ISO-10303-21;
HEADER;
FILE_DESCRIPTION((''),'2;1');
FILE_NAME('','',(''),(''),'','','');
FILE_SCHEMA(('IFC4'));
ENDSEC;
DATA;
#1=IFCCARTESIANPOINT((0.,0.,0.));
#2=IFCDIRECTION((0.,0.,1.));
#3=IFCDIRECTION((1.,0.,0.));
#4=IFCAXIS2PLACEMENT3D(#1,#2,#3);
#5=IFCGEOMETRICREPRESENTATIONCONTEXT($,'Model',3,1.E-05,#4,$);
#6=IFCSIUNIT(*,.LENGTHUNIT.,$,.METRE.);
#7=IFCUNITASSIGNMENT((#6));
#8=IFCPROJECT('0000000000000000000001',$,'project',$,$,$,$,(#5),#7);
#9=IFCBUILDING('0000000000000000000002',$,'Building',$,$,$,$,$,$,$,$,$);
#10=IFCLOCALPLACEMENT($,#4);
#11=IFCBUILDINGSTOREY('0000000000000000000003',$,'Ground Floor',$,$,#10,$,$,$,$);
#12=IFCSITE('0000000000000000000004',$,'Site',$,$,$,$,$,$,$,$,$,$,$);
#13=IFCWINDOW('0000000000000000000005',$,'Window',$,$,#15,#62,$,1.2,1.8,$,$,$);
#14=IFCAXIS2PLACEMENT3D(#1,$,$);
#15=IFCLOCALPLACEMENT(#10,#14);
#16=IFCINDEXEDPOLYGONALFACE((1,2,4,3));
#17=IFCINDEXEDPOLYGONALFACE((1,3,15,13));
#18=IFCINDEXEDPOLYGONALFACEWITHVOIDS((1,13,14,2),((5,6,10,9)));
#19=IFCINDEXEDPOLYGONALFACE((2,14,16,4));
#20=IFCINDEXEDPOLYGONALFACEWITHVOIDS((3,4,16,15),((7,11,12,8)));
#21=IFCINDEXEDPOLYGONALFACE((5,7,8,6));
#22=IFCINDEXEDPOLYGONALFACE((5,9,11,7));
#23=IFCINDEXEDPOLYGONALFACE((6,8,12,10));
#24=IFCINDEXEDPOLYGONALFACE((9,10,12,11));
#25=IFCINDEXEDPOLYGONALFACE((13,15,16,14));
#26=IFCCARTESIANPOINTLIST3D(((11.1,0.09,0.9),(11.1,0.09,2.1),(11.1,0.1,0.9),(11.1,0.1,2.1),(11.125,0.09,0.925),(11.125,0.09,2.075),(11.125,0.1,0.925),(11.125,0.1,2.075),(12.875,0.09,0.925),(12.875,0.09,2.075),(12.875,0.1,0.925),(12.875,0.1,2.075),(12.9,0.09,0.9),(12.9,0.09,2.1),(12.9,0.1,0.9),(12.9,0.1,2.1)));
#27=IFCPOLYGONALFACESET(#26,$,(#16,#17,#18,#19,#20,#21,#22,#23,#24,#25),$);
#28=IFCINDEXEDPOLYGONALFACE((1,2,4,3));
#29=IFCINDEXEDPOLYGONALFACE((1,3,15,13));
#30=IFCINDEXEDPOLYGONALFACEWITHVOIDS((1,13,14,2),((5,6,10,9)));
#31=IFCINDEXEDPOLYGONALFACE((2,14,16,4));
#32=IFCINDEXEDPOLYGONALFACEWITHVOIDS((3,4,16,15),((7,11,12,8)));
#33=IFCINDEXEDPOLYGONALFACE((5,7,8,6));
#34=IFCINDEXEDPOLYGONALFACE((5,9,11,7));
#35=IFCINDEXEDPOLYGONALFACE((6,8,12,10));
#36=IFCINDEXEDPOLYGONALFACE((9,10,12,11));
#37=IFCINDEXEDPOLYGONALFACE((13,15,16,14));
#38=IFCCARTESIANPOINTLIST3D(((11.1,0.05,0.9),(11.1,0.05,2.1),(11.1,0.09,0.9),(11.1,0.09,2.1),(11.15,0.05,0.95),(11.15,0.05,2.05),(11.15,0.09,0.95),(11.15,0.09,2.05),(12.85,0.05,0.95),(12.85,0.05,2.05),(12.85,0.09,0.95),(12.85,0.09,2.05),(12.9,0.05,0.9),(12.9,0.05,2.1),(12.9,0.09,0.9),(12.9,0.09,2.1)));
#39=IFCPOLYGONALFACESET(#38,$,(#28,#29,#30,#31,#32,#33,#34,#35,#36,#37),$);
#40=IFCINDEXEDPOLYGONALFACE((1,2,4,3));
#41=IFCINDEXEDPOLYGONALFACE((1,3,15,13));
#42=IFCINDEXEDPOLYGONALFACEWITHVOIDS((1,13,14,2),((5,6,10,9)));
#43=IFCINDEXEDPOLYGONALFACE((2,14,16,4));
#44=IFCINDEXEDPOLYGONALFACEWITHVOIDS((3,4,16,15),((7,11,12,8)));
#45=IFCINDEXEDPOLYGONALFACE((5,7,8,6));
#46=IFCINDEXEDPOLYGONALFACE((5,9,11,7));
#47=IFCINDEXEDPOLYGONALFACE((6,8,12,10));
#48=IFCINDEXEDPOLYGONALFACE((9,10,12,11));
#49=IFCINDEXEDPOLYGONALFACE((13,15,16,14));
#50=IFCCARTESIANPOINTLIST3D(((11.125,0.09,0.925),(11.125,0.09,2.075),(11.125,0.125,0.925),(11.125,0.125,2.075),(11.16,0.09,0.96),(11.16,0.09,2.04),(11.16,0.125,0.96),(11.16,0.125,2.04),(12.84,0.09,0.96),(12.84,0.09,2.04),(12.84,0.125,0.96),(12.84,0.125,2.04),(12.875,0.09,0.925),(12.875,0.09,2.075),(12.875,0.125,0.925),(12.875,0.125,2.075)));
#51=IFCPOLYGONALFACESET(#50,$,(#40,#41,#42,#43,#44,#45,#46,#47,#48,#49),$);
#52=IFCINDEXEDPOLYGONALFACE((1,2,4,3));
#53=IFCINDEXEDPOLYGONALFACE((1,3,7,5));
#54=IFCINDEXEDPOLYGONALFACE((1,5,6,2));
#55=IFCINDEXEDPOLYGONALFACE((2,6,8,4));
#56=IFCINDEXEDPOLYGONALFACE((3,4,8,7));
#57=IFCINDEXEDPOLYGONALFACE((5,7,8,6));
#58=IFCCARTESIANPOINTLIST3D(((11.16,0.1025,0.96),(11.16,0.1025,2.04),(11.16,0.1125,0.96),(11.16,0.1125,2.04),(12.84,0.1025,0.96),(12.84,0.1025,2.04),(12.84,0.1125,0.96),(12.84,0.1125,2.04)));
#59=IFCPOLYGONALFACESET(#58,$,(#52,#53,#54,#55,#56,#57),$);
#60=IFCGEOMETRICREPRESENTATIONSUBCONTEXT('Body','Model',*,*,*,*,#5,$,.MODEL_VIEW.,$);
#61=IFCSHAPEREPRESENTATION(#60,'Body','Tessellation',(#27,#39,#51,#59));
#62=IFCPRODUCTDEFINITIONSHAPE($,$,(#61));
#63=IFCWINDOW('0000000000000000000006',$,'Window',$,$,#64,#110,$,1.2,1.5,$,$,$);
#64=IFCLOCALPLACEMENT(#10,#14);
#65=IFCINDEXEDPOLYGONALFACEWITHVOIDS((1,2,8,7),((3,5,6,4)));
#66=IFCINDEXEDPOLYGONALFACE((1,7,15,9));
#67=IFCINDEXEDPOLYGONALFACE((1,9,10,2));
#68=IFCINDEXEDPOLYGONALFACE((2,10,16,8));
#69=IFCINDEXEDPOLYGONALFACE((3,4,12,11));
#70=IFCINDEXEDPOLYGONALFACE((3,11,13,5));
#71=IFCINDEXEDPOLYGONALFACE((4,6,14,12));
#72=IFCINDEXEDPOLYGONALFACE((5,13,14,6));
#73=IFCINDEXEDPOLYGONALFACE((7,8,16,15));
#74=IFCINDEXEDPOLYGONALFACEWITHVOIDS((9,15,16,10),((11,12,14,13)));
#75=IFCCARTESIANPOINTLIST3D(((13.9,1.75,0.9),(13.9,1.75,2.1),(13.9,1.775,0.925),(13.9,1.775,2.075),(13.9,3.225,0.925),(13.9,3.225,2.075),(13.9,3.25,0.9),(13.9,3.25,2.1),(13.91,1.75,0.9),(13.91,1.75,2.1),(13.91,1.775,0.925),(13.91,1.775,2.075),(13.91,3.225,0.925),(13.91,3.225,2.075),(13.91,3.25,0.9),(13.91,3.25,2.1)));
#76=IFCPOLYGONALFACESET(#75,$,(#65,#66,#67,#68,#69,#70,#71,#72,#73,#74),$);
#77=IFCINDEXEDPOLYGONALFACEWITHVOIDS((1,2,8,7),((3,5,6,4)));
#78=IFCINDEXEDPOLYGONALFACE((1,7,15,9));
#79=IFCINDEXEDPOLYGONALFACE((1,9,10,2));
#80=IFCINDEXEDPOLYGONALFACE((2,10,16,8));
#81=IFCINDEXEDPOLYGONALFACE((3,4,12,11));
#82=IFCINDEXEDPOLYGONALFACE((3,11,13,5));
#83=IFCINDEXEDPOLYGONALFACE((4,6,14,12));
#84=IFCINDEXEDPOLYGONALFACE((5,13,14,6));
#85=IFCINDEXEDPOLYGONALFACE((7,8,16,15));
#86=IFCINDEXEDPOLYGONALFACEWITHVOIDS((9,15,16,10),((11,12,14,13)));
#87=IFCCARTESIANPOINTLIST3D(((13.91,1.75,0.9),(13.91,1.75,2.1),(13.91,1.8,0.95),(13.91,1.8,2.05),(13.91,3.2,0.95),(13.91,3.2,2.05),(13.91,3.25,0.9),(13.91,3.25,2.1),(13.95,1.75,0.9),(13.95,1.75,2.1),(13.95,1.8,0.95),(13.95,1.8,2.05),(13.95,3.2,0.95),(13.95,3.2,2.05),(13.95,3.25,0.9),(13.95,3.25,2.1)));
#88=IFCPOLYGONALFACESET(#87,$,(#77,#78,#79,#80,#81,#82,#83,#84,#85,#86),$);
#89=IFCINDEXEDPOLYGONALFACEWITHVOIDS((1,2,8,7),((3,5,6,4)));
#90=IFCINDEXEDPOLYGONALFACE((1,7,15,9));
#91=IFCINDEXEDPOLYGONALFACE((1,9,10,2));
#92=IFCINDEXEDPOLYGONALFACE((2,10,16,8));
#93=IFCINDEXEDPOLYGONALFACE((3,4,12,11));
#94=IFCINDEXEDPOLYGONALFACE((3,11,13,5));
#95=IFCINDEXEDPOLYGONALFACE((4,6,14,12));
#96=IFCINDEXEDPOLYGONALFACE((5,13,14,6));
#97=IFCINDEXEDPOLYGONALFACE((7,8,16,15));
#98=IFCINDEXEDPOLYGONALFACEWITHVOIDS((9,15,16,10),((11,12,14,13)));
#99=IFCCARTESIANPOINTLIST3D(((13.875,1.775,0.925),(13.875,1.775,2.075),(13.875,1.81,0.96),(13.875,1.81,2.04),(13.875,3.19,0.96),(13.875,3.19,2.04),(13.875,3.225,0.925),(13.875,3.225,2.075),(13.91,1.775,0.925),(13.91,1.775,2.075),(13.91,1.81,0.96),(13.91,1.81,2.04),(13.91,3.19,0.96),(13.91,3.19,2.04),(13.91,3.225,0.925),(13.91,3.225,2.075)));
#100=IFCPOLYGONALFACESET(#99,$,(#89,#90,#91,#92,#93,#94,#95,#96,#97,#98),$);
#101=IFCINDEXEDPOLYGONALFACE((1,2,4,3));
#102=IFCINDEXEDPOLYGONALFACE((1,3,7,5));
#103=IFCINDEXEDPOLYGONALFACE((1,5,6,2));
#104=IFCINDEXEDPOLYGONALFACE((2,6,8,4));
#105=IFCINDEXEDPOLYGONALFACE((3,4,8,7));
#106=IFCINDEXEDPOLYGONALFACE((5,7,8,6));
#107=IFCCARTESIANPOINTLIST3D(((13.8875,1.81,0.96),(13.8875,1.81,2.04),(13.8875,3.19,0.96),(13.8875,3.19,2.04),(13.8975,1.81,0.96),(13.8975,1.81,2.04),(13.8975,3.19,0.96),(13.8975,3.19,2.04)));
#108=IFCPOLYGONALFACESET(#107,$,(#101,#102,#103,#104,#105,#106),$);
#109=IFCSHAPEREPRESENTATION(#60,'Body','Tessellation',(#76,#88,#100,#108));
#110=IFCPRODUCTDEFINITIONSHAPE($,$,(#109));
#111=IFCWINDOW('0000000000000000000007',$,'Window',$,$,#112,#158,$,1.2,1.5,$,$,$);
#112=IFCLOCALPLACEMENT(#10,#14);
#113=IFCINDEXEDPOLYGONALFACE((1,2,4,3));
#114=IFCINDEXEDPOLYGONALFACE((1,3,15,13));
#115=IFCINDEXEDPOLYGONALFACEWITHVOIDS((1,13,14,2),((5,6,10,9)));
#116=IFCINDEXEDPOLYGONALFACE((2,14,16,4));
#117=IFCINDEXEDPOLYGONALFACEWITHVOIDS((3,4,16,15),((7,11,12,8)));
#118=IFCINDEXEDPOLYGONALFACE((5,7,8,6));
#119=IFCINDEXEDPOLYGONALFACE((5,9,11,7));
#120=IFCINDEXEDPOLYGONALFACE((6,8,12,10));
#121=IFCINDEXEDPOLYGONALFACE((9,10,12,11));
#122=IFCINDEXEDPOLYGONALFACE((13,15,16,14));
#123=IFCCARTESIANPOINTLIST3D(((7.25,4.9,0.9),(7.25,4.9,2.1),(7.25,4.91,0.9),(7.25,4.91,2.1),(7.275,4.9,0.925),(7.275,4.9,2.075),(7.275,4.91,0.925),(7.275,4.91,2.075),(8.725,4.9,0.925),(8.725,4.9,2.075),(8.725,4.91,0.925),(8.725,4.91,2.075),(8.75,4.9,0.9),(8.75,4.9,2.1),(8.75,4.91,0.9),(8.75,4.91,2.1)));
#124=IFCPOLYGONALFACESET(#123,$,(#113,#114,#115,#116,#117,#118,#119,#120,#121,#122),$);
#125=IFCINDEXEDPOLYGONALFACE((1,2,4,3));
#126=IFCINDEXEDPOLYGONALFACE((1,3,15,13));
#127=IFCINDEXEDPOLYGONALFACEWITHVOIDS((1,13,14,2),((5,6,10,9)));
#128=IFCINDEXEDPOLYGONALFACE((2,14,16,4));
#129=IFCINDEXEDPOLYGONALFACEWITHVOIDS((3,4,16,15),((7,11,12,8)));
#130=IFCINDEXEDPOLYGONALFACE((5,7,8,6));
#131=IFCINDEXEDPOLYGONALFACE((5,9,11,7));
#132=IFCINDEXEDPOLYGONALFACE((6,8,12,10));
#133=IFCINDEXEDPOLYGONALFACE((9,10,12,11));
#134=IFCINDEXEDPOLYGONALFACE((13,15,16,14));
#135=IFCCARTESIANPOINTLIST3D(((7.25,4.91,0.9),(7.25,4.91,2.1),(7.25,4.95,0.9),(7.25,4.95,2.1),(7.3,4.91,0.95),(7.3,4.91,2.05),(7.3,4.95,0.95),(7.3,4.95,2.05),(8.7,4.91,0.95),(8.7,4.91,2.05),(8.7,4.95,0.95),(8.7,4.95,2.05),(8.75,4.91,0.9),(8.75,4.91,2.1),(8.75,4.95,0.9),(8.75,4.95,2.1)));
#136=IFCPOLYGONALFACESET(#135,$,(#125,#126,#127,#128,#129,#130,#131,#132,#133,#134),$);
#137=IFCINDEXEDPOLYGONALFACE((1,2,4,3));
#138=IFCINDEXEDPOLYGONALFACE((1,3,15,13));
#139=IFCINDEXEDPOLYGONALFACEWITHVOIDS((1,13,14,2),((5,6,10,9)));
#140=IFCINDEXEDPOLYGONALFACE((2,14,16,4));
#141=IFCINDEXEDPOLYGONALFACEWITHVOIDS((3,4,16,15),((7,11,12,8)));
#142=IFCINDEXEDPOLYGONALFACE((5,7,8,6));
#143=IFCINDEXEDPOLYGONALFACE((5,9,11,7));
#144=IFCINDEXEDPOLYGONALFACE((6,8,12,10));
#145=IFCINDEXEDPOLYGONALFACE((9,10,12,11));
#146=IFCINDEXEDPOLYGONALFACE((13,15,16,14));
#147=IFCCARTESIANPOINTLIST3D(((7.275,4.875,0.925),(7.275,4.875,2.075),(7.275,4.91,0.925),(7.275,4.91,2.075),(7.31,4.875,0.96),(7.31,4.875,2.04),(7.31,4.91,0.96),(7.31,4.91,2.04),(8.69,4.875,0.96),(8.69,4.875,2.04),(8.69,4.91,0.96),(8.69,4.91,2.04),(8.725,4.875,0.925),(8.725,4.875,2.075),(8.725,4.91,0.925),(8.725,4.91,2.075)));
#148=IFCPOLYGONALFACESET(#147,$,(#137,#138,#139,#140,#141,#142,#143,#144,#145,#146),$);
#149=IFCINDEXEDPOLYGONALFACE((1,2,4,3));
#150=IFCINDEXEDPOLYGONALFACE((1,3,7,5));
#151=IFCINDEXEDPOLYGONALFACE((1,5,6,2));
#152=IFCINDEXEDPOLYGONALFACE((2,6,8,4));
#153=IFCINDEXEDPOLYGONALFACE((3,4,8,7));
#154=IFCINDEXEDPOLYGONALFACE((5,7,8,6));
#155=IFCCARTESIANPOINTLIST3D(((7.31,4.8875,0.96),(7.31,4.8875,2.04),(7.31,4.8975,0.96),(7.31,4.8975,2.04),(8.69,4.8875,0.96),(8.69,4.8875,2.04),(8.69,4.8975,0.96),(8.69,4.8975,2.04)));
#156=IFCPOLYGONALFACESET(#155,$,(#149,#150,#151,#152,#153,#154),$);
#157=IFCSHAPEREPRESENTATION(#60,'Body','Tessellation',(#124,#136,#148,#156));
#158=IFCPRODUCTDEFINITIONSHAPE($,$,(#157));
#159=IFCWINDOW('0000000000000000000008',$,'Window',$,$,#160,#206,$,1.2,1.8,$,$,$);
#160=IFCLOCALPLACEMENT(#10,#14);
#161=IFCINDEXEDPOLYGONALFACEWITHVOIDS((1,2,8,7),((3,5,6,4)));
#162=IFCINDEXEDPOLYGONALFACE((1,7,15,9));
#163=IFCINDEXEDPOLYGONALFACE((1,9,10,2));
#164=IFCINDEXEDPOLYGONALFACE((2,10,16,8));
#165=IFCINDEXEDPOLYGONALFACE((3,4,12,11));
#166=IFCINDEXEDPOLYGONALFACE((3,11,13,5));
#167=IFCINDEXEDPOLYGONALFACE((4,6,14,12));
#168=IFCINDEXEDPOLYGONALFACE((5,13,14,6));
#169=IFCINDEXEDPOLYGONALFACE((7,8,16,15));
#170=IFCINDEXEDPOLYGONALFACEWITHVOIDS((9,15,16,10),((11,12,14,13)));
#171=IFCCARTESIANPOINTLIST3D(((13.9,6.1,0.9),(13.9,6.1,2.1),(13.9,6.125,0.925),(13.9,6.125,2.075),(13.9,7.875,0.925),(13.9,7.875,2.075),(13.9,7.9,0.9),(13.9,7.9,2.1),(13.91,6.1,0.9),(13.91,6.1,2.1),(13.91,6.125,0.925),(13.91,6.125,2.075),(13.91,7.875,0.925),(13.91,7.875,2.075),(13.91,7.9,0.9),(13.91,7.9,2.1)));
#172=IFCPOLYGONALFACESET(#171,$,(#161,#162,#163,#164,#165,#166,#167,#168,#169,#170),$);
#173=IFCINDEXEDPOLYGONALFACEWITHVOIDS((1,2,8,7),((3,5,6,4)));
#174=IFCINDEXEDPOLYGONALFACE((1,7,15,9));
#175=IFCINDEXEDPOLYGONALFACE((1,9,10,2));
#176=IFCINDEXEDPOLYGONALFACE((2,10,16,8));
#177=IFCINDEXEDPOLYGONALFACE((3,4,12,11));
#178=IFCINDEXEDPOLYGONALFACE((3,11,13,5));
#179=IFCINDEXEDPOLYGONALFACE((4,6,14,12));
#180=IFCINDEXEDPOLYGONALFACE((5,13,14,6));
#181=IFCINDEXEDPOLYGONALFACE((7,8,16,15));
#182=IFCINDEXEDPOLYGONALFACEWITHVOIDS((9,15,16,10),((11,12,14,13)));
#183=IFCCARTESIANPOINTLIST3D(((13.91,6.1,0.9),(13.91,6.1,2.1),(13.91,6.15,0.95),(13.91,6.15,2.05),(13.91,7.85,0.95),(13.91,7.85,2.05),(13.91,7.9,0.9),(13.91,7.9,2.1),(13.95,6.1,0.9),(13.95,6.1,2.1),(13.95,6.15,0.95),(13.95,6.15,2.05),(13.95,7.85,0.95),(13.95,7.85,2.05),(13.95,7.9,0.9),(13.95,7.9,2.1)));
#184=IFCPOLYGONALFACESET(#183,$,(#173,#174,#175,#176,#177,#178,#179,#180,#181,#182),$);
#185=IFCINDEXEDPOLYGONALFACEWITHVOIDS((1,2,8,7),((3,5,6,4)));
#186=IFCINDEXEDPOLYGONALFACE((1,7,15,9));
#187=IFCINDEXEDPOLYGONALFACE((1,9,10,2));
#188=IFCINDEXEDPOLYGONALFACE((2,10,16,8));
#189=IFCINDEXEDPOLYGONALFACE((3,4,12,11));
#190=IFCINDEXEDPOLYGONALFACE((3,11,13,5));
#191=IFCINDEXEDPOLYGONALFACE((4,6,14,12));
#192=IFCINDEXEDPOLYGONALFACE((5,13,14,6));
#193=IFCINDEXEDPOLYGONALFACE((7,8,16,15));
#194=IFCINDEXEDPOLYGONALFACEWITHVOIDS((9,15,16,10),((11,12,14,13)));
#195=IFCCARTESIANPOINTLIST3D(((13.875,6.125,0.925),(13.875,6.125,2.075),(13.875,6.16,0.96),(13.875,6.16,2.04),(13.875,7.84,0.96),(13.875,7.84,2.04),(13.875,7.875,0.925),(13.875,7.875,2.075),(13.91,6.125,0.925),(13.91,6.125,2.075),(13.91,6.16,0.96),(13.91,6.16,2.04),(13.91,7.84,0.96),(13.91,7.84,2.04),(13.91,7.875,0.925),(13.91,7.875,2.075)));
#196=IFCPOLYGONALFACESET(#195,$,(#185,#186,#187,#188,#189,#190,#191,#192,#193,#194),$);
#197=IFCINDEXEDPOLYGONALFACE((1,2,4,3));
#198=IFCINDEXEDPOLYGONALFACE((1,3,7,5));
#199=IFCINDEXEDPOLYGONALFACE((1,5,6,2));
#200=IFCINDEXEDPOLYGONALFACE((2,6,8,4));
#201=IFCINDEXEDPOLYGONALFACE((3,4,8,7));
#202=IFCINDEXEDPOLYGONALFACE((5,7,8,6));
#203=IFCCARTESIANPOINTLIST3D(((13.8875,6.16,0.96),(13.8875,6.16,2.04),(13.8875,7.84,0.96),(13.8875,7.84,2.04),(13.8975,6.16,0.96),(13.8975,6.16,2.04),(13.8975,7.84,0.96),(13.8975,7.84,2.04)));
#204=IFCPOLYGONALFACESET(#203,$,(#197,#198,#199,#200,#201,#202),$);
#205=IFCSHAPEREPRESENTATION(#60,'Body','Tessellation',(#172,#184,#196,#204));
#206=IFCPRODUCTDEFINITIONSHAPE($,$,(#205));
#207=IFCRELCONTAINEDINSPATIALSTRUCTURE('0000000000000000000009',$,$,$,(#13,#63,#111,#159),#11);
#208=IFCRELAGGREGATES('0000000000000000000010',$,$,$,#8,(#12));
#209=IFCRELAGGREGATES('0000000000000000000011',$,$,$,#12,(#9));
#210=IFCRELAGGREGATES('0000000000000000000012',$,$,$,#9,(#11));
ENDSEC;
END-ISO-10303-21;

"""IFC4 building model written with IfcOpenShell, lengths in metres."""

from ifc_helpers import new_model, si_unit, frame, origin_with_axes, place, context, subcontext, project, spatial, line, indexed_curve, outline, extrude, element, save


model = new_model("IFC4")

# Units and contexts
model_context = context("Model", 3, precision=1e-05, world=origin_with_axes())
body_context = subcontext(model_context, "Body", "Model", "MODEL_VIEW")
ifc_project = project(units=[si_unit("LENGTHUNIT", "METRE")], contexts=[model_context])

# Site, building, storey
site = spatial("IfcSite", under=ifc_project, Name="Site")
building = spatial("IfcBuilding", under=site, Name="Building")
storey_placement = place(None, origin_with_axes())
storey = spatial("IfcBuildingStorey", under=building, at=storey_placement, Name="Ground Floor")

# Windows
window_1_placement = place(storey_placement, frame((11.1, 0.0, 0.9), z_axis=(0.0, 0.0, 1.0), x_axis=(1.0, 0.0, 0.0)))
element("IfcWindow", 1, at=window_1_placement, inside=storey, Name="Window", OverallHeight=1.2, OverallWidth=1.8, context=body_context, shape_type="SweptSolid", body=[
    extrude(outline(indexed_curve([(0.0, 0.0), (1.8, 0.0), (1.8, 1.2), (0.0, 1.2)], segments=[line(1, 2, 3, 4, 1)]), holes=[indexed_curve([(0.025, 0.025), (1.775, 0.025), (1.775, 1.175), (0.025, 1.175)], segments=[line(1, 2, 3, 4, 1)])]), frame((0.0, 0.09, 0.0), z_axis=(0.0, -1.0, 0.0), x_axis=(1.0, 0.0, 0.0)), (0.0, 0.0, -1.0), 0.01),
    extrude(outline(indexed_curve([(0.0, 0.0), (1.8, 0.0), (1.8, 1.2), (0.0, 1.2)], segments=[line(1, 2, 3, 4, 1)]), holes=[indexed_curve([(0.05, 0.05), (1.75, 0.05), (1.75, 1.15), (0.05, 1.15)], segments=[line(1, 2, 3, 4, 1)])]), frame((0.0, 0.05, 0.0), z_axis=(0.0, -1.0, 0.0), x_axis=(1.0, 0.0, 0.0)), (0.0, 0.0, -1.0), 0.04),
    extrude(outline(indexed_curve([(0.0, 0.0), (1.75, 0.0), (1.75, 1.15), (0.0, 1.15)], segments=[line(1, 2, 3, 4, 1)]), holes=[indexed_curve([(0.035, 0.035), (1.715, 0.035), (1.715, 1.115), (0.035, 1.115)], segments=[line(1, 2, 3, 4, 1)])]), frame((0.025, 0.09, 0.025), z_axis=(0.0, -1.0, 0.0), x_axis=(1.0, 0.0, 0.0)), (0.0, 0.0, -1.0), 0.035),
    extrude(outline(indexed_curve([(0.035, 0.035), (1.715, 0.035), (1.715, 1.115), (0.035, 1.115)], segments=[line(1, 2, 3, 4, 1)])), frame((0.025, 0.1025, 0.025), z_axis=(0.0, -1.0, 0.0), x_axis=(1.0, 0.0, 0.0)), (0.0, 0.0, -1.0), 0.01),
])
for number, where, z_axis, x_axis, name in (
    (2, (14.0, 1.75, 0.9), (0.0, 0.0, 1.0), (0.0, 1.0, 0.0), "Window"),
    (3, (8.75, 5.0, 0.9), (0.0, 0.0, 1.0), (-1.0, 0.0, 0.0), "Window"),
):
    element("IfcWindow", number, at=place(storey_placement, frame(where, z_axis=z_axis, x_axis=x_axis)), inside=storey, Name=name, OverallHeight=1.2, OverallWidth=1.5, context=body_context, shape_type="SweptSolid", body=[
        extrude(outline(indexed_curve([(0.0, 0.0), (1.5, 0.0), (1.5, 1.2), (0.0, 1.2)], segments=[line(1, 2, 3, 4, 1)]), holes=[indexed_curve([(0.025, 0.025), (1.475, 0.025), (1.475, 1.175), (0.025, 1.175)], segments=[line(1, 2, 3, 4, 1)])]), frame((0.0, 0.09, 0.0), z_axis=(0.0, -1.0, 0.0), x_axis=(1.0, 0.0, 0.0)), (0.0, 0.0, -1.0), 0.01),
        extrude(outline(indexed_curve([(0.0, 0.0), (1.5, 0.0), (1.5, 1.2), (0.0, 1.2)], segments=[line(1, 2, 3, 4, 1)]), holes=[indexed_curve([(0.05, 0.05), (1.45, 0.05), (1.45, 1.15), (0.05, 1.15)], segments=[line(1, 2, 3, 4, 1)])]), frame((0.0, 0.05, 0.0), z_axis=(0.0, -1.0, 0.0), x_axis=(1.0, 0.0, 0.0)), (0.0, 0.0, -1.0), 0.04),
        extrude(outline(indexed_curve([(0.0, 0.0), (1.45, 0.0), (1.45, 1.15), (0.0, 1.15)], segments=[line(1, 2, 3, 4, 1)]), holes=[indexed_curve([(0.035, 0.035), (1.415, 0.035), (1.415, 1.115), (0.035, 1.115)], segments=[line(1, 2, 3, 4, 1)])]), frame((0.025, 0.09, 0.025), z_axis=(0.0, -1.0, 0.0), x_axis=(1.0, 0.0, 0.0)), (0.0, 0.0, -1.0), 0.035),
        extrude(outline(indexed_curve([(0.035, 0.035), (1.415, 0.035), (1.415, 1.115), (0.035, 1.115)], segments=[line(1, 2, 3, 4, 1)])), frame((0.025, 0.1025, 0.025), z_axis=(0.0, -1.0, 0.0), x_axis=(1.0, 0.0, 0.0)), (0.0, 0.0, -1.0), 0.01),
    ])
window_2_placement = place(storey_placement, frame((14.0, 6.1, 0.9), z_axis=(0.0, 0.0, 1.0), x_axis=(0.0, 1.0, 0.0)))
element("IfcWindow", 4, at=window_2_placement, inside=storey, Name="Window", OverallHeight=1.2, OverallWidth=1.8, context=body_context, shape_type="SweptSolid", body=[
    extrude(outline(indexed_curve([(0.0, 0.0), (1.8, 0.0), (1.8, 1.2), (0.0, 1.2)], segments=[line(1, 2, 3, 4, 1)]), holes=[indexed_curve([(0.025, 0.025), (1.775, 0.025), (1.775, 1.175), (0.025, 1.175)], segments=[line(1, 2, 3, 4, 1)])]), frame((0.0, 0.09, 0.0), z_axis=(0.0, -1.0, 0.0), x_axis=(1.0, 0.0, 0.0)), (0.0, 0.0, -1.0), 0.01),
    extrude(outline(indexed_curve([(0.0, 0.0), (1.8, 0.0), (1.8, 1.2), (0.0, 1.2)], segments=[line(1, 2, 3, 4, 1)]), holes=[indexed_curve([(0.05, 0.05), (1.75, 0.05), (1.75, 1.15), (0.05, 1.15)], segments=[line(1, 2, 3, 4, 1)])]), frame((0.0, 0.05, 0.0), z_axis=(0.0, -1.0, 0.0), x_axis=(1.0, 0.0, 0.0)), (0.0, 0.0, -1.0), 0.04),
    extrude(outline(indexed_curve([(0.0, 0.0), (1.75, 0.0), (1.75, 1.15), (0.0, 1.15)], segments=[line(1, 2, 3, 4, 1)]), holes=[indexed_curve([(0.035, 0.035), (1.715, 0.035), (1.715, 1.115), (0.035, 1.115)], segments=[line(1, 2, 3, 4, 1)])]), frame((0.025, 0.09, 0.025), z_axis=(0.0, -1.0, 0.0), x_axis=(1.0, 0.0, 0.0)), (0.0, 0.0, -1.0), 0.035),
    extrude(outline(indexed_curve([(0.035, 0.035), (1.715, 0.035), (1.715, 1.115), (0.035, 1.115)], segments=[line(1, 2, 3, 4, 1)])), frame((0.025, 0.1025, 0.025), z_axis=(0.0, -1.0, 0.0), x_axis=(1.0, 0.0, 0.0)), (0.0, 0.0, -1.0), 0.01),
])

save(model, "model.ifc")
